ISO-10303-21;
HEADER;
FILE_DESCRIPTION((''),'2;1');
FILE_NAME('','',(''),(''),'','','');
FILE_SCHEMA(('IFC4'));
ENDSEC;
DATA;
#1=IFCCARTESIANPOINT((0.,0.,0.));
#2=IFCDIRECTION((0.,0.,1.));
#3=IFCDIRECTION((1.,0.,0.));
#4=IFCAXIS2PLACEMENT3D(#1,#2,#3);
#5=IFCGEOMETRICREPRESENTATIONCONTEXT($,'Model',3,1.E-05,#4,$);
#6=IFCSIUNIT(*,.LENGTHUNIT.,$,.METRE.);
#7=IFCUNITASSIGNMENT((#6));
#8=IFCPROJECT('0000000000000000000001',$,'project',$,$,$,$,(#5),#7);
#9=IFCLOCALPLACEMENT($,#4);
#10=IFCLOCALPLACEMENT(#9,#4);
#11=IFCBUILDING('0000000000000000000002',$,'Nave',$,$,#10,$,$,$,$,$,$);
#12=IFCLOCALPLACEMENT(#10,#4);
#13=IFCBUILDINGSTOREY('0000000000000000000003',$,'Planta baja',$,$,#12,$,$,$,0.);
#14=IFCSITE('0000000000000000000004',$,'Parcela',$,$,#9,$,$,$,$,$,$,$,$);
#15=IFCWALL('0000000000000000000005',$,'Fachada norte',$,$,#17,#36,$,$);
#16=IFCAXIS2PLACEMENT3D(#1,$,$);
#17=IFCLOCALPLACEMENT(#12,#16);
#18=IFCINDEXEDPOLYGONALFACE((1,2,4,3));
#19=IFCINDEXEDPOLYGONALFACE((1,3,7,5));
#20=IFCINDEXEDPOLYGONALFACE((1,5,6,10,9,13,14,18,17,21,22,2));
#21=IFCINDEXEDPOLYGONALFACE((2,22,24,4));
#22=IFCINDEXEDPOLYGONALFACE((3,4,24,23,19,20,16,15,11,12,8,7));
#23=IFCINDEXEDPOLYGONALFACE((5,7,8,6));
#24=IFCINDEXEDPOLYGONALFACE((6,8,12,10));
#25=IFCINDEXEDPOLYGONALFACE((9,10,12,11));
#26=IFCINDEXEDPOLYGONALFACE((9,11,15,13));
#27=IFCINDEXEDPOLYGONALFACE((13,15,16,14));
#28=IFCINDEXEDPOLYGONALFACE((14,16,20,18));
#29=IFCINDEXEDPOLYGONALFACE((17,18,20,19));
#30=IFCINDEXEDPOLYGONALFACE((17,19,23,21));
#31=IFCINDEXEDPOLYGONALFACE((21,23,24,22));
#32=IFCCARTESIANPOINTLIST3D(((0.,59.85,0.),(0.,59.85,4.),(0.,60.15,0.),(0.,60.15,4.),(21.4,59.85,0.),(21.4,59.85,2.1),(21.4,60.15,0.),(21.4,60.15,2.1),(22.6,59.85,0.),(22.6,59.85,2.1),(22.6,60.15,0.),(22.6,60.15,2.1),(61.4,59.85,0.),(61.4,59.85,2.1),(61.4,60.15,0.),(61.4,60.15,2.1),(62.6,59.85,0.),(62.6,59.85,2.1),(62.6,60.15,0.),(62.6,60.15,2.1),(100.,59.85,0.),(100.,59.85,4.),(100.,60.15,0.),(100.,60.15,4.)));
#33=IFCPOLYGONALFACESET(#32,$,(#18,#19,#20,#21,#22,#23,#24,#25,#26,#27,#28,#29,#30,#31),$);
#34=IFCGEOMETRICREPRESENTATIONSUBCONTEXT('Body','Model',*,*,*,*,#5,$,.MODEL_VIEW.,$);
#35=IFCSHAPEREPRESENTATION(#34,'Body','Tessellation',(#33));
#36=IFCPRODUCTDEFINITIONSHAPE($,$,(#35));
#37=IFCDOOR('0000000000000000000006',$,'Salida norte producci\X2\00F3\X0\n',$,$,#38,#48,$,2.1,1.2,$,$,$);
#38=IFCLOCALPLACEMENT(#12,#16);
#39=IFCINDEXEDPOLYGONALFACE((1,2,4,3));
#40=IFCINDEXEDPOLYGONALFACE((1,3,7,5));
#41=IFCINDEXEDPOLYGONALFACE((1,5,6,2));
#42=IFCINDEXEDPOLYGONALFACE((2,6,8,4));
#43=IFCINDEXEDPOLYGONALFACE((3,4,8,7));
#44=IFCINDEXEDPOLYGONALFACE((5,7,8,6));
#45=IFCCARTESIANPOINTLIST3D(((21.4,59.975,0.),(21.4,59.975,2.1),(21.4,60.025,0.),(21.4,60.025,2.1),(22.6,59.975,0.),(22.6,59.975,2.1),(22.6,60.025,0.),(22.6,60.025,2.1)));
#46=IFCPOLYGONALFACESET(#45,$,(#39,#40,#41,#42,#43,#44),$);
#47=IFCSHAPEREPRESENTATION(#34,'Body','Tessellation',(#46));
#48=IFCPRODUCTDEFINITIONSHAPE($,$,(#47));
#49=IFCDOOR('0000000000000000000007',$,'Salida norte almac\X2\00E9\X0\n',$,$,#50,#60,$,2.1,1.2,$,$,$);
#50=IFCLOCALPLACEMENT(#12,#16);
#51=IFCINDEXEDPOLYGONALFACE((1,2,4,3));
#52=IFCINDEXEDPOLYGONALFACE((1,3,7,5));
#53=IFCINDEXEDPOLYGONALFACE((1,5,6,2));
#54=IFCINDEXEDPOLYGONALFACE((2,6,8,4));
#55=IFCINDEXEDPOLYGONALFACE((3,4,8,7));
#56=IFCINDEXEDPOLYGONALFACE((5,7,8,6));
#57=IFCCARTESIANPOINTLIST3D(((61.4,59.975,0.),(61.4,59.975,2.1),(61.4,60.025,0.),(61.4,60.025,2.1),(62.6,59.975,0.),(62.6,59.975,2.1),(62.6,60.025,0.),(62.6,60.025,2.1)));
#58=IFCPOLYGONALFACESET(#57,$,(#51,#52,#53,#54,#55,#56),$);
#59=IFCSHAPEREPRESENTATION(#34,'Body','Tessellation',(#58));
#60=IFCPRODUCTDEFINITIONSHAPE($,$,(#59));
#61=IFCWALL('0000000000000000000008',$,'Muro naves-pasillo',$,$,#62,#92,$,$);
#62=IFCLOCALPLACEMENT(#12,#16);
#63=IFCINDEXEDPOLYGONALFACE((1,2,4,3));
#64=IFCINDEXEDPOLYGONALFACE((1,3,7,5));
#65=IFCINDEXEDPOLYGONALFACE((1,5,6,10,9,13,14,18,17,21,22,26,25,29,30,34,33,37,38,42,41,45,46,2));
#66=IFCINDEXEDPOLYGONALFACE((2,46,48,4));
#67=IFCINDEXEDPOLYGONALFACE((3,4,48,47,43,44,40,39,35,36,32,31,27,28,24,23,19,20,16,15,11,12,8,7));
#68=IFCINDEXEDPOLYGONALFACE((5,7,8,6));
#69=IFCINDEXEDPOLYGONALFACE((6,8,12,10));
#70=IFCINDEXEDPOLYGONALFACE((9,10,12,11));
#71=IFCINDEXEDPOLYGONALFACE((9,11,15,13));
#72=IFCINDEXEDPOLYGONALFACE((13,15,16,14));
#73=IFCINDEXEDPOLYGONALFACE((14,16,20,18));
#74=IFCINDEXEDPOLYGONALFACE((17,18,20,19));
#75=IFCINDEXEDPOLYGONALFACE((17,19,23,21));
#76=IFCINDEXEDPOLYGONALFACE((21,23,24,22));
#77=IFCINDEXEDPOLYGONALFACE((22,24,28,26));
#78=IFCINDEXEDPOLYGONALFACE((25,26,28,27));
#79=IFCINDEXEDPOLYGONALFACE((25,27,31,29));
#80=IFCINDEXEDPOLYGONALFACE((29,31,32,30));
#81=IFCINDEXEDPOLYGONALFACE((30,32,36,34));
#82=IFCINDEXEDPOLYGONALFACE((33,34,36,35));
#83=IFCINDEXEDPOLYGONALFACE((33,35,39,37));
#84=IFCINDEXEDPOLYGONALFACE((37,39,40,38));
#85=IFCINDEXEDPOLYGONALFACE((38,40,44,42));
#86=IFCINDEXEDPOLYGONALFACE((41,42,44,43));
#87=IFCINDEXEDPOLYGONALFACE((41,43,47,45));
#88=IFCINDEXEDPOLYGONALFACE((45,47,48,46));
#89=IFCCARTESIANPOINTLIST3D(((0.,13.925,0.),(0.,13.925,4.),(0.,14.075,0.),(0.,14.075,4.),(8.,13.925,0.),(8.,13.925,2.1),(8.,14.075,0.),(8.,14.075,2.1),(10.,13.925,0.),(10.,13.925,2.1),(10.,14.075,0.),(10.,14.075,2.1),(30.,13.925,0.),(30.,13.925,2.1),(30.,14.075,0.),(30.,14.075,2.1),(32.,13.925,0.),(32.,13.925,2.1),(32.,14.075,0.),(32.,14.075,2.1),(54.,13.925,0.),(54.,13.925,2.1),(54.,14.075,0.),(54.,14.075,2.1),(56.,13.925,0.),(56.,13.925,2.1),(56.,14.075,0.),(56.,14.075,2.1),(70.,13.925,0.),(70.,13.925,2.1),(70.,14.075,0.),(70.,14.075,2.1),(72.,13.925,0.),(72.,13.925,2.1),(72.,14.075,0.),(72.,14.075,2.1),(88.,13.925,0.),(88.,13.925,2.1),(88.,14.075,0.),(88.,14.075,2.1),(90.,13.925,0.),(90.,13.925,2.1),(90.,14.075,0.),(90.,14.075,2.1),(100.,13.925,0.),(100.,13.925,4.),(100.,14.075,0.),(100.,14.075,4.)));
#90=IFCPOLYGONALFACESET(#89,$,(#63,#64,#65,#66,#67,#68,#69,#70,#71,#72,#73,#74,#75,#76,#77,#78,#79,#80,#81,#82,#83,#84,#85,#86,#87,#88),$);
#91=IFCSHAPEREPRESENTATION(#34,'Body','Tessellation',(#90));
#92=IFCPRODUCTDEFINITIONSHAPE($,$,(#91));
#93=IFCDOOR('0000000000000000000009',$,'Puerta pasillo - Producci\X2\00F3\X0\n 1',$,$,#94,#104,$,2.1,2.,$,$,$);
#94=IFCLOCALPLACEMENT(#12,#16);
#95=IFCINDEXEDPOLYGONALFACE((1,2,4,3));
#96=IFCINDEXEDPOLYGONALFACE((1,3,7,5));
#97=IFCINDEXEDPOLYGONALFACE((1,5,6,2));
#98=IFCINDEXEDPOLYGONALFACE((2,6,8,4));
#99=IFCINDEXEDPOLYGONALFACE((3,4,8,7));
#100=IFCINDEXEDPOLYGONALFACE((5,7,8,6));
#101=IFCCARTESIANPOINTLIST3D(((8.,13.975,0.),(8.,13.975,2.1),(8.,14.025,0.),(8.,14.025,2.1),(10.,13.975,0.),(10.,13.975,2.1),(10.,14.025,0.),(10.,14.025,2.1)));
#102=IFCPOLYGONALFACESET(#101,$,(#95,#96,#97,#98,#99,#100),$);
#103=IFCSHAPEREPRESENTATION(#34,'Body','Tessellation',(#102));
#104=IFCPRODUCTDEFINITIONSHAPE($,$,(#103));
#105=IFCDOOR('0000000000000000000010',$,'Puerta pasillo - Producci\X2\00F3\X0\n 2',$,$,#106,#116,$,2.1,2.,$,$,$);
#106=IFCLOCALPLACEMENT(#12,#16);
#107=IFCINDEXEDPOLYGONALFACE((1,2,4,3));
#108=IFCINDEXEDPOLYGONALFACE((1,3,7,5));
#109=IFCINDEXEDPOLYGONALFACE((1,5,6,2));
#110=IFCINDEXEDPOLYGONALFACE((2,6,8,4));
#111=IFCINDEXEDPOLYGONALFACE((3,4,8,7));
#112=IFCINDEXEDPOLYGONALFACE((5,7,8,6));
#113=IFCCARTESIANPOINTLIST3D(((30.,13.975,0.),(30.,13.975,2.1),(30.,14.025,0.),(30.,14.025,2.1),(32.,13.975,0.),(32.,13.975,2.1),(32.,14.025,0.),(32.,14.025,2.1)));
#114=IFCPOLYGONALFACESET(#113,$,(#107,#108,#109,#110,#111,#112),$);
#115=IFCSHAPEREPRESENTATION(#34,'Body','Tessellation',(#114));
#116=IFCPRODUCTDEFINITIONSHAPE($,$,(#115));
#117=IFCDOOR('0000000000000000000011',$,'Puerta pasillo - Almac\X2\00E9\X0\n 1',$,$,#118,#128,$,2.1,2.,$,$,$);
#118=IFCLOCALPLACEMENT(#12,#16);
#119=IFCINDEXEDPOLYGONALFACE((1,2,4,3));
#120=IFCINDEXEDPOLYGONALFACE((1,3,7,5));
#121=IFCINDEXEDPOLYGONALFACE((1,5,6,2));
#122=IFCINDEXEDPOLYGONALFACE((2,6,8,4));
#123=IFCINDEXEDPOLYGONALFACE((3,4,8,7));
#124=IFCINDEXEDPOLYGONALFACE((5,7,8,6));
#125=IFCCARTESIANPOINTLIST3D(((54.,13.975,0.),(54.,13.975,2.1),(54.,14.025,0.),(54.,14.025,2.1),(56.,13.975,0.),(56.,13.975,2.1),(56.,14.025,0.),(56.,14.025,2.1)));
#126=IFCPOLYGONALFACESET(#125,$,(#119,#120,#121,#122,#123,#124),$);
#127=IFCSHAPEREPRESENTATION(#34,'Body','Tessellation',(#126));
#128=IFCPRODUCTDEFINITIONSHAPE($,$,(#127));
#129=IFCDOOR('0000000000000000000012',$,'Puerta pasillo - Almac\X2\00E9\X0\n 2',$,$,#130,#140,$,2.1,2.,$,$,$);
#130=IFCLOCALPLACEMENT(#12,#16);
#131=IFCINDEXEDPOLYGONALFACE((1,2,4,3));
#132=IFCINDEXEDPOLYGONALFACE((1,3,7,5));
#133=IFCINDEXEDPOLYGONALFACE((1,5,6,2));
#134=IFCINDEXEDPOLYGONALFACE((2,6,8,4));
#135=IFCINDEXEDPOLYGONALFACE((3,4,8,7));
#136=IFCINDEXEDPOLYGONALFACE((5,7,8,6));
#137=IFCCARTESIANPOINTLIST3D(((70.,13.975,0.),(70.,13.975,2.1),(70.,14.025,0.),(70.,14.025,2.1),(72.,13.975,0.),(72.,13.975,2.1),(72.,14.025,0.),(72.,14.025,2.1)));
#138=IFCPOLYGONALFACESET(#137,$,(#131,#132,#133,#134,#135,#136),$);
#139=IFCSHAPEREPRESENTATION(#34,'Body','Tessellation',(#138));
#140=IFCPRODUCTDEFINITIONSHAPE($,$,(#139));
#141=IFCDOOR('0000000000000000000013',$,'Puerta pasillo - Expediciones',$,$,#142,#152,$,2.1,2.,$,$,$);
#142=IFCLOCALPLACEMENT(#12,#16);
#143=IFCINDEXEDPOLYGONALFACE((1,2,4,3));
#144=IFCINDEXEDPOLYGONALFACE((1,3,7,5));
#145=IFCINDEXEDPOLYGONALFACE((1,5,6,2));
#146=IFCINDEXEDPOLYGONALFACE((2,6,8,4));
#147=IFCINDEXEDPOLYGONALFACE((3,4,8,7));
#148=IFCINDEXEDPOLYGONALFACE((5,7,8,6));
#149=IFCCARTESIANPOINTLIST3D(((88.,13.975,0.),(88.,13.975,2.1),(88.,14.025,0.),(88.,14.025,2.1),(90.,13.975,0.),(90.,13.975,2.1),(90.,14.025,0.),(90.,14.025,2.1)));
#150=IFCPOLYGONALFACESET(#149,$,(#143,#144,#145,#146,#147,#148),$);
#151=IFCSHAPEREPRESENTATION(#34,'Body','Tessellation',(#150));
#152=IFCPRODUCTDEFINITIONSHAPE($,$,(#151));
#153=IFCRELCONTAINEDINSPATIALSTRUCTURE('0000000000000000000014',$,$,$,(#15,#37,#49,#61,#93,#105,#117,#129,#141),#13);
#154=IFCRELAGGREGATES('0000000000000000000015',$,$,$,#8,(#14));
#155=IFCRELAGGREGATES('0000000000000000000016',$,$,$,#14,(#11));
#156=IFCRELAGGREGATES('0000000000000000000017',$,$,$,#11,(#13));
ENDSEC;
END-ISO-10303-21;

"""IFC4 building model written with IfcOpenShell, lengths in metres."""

from ifc_helpers import new_model, si_unit, frame, origin_with_axes, place, context, subcontext, project, spatial, indexed_curve, outline, extrude, element, fill, save


model = new_model("IFC4")

# Units and contexts
model_context = context("Model", 3, precision=1e-05, world=origin_with_axes())
body_context = subcontext(model_context, "Body", "Model", "MODEL_VIEW")
ifc_project = project(units=[si_unit("LENGTHUNIT", "METRE")], contexts=[model_context])

# Site, building, storey
site_placement = place(None, origin_with_axes())
site = spatial("IfcSite", under=ifc_project, at=site_placement, Name="Parcela")
building_placement = place(site_placement, origin_with_axes())
building = spatial("IfcBuilding", under=site, at=building_placement, Name="Nave")
storey_placement = place(building_placement, origin_with_axes())
storey = spatial("IfcBuildingStorey", under=building, at=storey_placement, Name="Planta baja", Elevation=0.0)

# Walls, openings, doors
wall_1_placement = place(storey_placement, frame((0.0, 59.85, 0.0), z_axis=(0.0, 0.0, 1.0), x_axis=(1.0, 0.0, 0.0)))
wall_1 = element("IfcWall", 1, at=wall_1_placement, inside=storey, Name="Fachada norte", context=body_context, shape_type="SweptSolid", body=[
    extrude(outline(indexed_curve([(0.0, 0.0), (0.0, 0.3), (100.0, 0.3), (100.0, 0.0), (0.0, 0.0)], self_intersect=False)), origin_with_axes(), (0.0, 0.0, 1.0), 4.0),
])
opening_1_placement = place(wall_1_placement, frame((21.4, -0.05, 0.0), z_axis=(0.0, 0.0, 1.0), x_axis=(1.0, 0.0, 0.0)))
opening_1 = element("IfcOpeningElement", 2, at=opening_1_placement, cuts=wall_1, context=body_context, shape_type="SweptSolid", body=[
    extrude(outline(indexed_curve([(0.0, 0.0), (0.0, 0.4), (1.2, 0.4), (1.2, 0.0), (0.0, 0.0)], self_intersect=False)), origin_with_axes(), (0.0, 0.0, 1.0), 2.1),
])
opening_2_placement = place(wall_1_placement, frame((61.4, -0.05, 0.0), z_axis=(0.0, 0.0, 1.0), x_axis=(1.0, 0.0, 0.0)))
opening_2 = element("IfcOpeningElement", 3, at=opening_2_placement, cuts=wall_1, context=body_context, shape_type="SweptSolid", body=[
    extrude(outline(indexed_curve([(0.0, 0.0), (0.0, 0.4), (1.2, 0.4), (1.2, 0.0), (0.0, 0.0)], self_intersect=False)), origin_with_axes(), (0.0, 0.0, 1.0), 2.1),
])
door_1_placement = place(opening_1_placement, frame((0.0, 0.175, 0.0), z_axis=(0.0, 0.0, 1.0), x_axis=(1.0, 0.0, 0.0)))
door_1 = element("IfcDoor", 4, at=door_1_placement, inside=storey, Name="Salida norte producción", OverallHeight=2.1, OverallWidth=1.2, context=body_context, shape_type="SweptSolid", body=[
    extrude(outline(indexed_curve([(0.0, 0.0), (0.0, 0.05), (1.2, 0.05), (1.2, 0.0), (0.0, 0.0)], self_intersect=False)), origin_with_axes(), (0.0, 0.0, 1.0), 2.1),
])
fill(opening_1, door_1)
door_2_placement = place(opening_2_placement, frame((0.0, 0.175, 0.0), z_axis=(0.0, 0.0, 1.0), x_axis=(1.0, 0.0, 0.0)))
door_2 = element("IfcDoor", 5, at=door_2_placement, inside=storey, Name="Salida norte almacén", OverallHeight=2.1, OverallWidth=1.2, context=body_context, shape_type="SweptSolid", body=[
    extrude(outline(indexed_curve([(0.0, 0.0), (0.0, 0.05), (1.2, 0.05), (1.2, 0.0), (0.0, 0.0)], self_intersect=False)), origin_with_axes(), (0.0, 0.0, 1.0), 2.1),
])
fill(opening_2, door_2)
wall_2_placement = place(storey_placement, frame((0.0, 13.925, 0.0), z_axis=(0.0, 0.0, 1.0), x_axis=(1.0, 0.0, 0.0)))
wall_2 = element("IfcWall", 6, at=wall_2_placement, inside=storey, Name="Muro naves-pasillo", context=body_context, shape_type="SweptSolid", body=[
    extrude(outline(indexed_curve([(0.0, 0.0), (0.0, 0.15), (100.0, 0.15), (100.0, 0.0), (0.0, 0.0)], self_intersect=False)), origin_with_axes(), (0.0, 0.0, 1.0), 4.0),
])
opening_3_placement = place(wall_2_placement, frame((8.0, -0.05, 0.0), z_axis=(0.0, 0.0, 1.0), x_axis=(1.0, 0.0, 0.0)))
opening_3 = element("IfcOpeningElement", 7, at=opening_3_placement, cuts=wall_2, context=body_context, shape_type="SweptSolid", body=[
    extrude(outline(indexed_curve([(0.0, 0.0), (0.0, 0.25), (2.0, 0.25), (2.0, 0.0), (0.0, 0.0)], self_intersect=False)), origin_with_axes(), (0.0, 0.0, 1.0), 2.1),
])
opening_4_placement = place(wall_2_placement, frame((30.0, -0.05, 0.0), z_axis=(0.0, 0.0, 1.0), x_axis=(1.0, 0.0, 0.0)))
opening_4 = element("IfcOpeningElement", 8, at=opening_4_placement, cuts=wall_2, context=body_context, shape_type="SweptSolid", body=[
    extrude(outline(indexed_curve([(0.0, 0.0), (0.0, 0.25), (2.0, 0.25), (2.0, 0.0), (0.0, 0.0)], self_intersect=False)), origin_with_axes(), (0.0, 0.0, 1.0), 2.1),
])
opening_5_placement = place(wall_2_placement, frame((54.0, -0.05, 0.0), z_axis=(0.0, 0.0, 1.0), x_axis=(1.0, 0.0, 0.0)))
opening_5 = element("IfcOpeningElement", 9, at=opening_5_placement, cuts=wall_2, context=body_context, shape_type="SweptSolid", body=[
    extrude(outline(indexed_curve([(0.0, 0.0), (0.0, 0.25), (2.0, 0.25), (2.0, 0.0), (0.0, 0.0)], self_intersect=False)), origin_with_axes(), (0.0, 0.0, 1.0), 2.1),
])
opening_6_placement = place(wall_2_placement, frame((70.0, -0.05, 0.0), z_axis=(0.0, 0.0, 1.0), x_axis=(1.0, 0.0, 0.0)))
opening_6 = element("IfcOpeningElement", 10, at=opening_6_placement, cuts=wall_2, context=body_context, shape_type="SweptSolid", body=[
    extrude(outline(indexed_curve([(0.0, 0.0), (0.0, 0.25), (2.0, 0.25), (2.0, 0.0), (0.0, 0.0)], self_intersect=False)), origin_with_axes(), (0.0, 0.0, 1.0), 2.1),
])
opening_7_placement = place(wall_2_placement, frame((88.0, -0.05, 0.0), z_axis=(0.0, 0.0, 1.0), x_axis=(1.0, 0.0, 0.0)))
opening_7 = element("IfcOpeningElement", 11, at=opening_7_placement, cuts=wall_2, context=body_context, shape_type="SweptSolid", body=[
    extrude(outline(indexed_curve([(0.0, 0.0), (0.0, 0.25), (2.0, 0.25), (2.0, 0.0), (0.0, 0.0)], self_intersect=False)), origin_with_axes(), (0.0, 0.0, 1.0), 2.1),
])
door_3_placement = place(opening_3_placement, frame((0.0, 0.1, 0.0), z_axis=(0.0, 0.0, 1.0), x_axis=(1.0, 0.0, 0.0)))
door_3 = element("IfcDoor", 12, at=door_3_placement, inside=storey, Name="Puerta pasillo - Producción 1", OverallHeight=2.1, OverallWidth=2.0, context=body_context, shape_type="SweptSolid", body=[
    extrude(outline(indexed_curve([(0.0, 0.0), (0.0, 0.05), (2.0, 0.05), (2.0, 0.0), (0.0, 0.0)], self_intersect=False)), origin_with_axes(), (0.0, 0.0, 1.0), 2.1),
])
fill(opening_3, door_3)
door_4_placement = place(opening_4_placement, frame((0.0, 0.1, 0.0), z_axis=(0.0, 0.0, 1.0), x_axis=(1.0, 0.0, 0.0)))
door_4 = element("IfcDoor", 13, at=door_4_placement, inside=storey, Name="Puerta pasillo - Producción 2", OverallHeight=2.1, OverallWidth=2.0, context=body_context, shape_type="SweptSolid", body=[
    extrude(outline(indexed_curve([(0.0, 0.0), (0.0, 0.05), (2.0, 0.05), (2.0, 0.0), (0.0, 0.0)], self_intersect=False)), origin_with_axes(), (0.0, 0.0, 1.0), 2.1),
])
fill(opening_4, door_4)
door_5_placement = place(opening_5_placement, frame((0.0, 0.1, 0.0), z_axis=(0.0, 0.0, 1.0), x_axis=(1.0, 0.0, 0.0)))
door_5 = element("IfcDoor", 14, at=door_5_placement, inside=storey, Name="Puerta pasillo - Almacén 1", OverallHeight=2.1, OverallWidth=2.0, context=body_context, shape_type="SweptSolid", body=[
    extrude(outline(indexed_curve([(0.0, 0.0), (0.0, 0.05), (2.0, 0.05), (2.0, 0.0), (0.0, 0.0)], self_intersect=False)), origin_with_axes(), (0.0, 0.0, 1.0), 2.1),
])
fill(opening_5, door_5)
door_6_placement = place(opening_6_placement, frame((0.0, 0.1, 0.0), z_axis=(0.0, 0.0, 1.0), x_axis=(1.0, 0.0, 0.0)))
door_6 = element("IfcDoor", 15, at=door_6_placement, inside=storey, Name="Puerta pasillo - Almacén 2", OverallHeight=2.1, OverallWidth=2.0, context=body_context, shape_type="SweptSolid", body=[
    extrude(outline(indexed_curve([(0.0, 0.0), (0.0, 0.05), (2.0, 0.05), (2.0, 0.0), (0.0, 0.0)], self_intersect=False)), origin_with_axes(), (0.0, 0.0, 1.0), 2.1),
])
fill(opening_6, door_6)
door_7_placement = place(opening_7_placement, frame((0.0, 0.1, 0.0), z_axis=(0.0, 0.0, 1.0), x_axis=(1.0, 0.0, 0.0)))
door_7 = element("IfcDoor", 16, at=door_7_placement, inside=storey, Name="Puerta pasillo - Expediciones", OverallHeight=2.1, OverallWidth=2.0, context=body_context, shape_type="SweptSolid", body=[
    extrude(outline(indexed_curve([(0.0, 0.0), (0.0, 0.05), (2.0, 0.05), (2.0, 0.0), (0.0, 0.0)], self_intersect=False)), origin_with_axes(), (0.0, 0.0, 1.0), 2.1),
])
fill(opening_7, door_7)

save(model, "model.ifc")
